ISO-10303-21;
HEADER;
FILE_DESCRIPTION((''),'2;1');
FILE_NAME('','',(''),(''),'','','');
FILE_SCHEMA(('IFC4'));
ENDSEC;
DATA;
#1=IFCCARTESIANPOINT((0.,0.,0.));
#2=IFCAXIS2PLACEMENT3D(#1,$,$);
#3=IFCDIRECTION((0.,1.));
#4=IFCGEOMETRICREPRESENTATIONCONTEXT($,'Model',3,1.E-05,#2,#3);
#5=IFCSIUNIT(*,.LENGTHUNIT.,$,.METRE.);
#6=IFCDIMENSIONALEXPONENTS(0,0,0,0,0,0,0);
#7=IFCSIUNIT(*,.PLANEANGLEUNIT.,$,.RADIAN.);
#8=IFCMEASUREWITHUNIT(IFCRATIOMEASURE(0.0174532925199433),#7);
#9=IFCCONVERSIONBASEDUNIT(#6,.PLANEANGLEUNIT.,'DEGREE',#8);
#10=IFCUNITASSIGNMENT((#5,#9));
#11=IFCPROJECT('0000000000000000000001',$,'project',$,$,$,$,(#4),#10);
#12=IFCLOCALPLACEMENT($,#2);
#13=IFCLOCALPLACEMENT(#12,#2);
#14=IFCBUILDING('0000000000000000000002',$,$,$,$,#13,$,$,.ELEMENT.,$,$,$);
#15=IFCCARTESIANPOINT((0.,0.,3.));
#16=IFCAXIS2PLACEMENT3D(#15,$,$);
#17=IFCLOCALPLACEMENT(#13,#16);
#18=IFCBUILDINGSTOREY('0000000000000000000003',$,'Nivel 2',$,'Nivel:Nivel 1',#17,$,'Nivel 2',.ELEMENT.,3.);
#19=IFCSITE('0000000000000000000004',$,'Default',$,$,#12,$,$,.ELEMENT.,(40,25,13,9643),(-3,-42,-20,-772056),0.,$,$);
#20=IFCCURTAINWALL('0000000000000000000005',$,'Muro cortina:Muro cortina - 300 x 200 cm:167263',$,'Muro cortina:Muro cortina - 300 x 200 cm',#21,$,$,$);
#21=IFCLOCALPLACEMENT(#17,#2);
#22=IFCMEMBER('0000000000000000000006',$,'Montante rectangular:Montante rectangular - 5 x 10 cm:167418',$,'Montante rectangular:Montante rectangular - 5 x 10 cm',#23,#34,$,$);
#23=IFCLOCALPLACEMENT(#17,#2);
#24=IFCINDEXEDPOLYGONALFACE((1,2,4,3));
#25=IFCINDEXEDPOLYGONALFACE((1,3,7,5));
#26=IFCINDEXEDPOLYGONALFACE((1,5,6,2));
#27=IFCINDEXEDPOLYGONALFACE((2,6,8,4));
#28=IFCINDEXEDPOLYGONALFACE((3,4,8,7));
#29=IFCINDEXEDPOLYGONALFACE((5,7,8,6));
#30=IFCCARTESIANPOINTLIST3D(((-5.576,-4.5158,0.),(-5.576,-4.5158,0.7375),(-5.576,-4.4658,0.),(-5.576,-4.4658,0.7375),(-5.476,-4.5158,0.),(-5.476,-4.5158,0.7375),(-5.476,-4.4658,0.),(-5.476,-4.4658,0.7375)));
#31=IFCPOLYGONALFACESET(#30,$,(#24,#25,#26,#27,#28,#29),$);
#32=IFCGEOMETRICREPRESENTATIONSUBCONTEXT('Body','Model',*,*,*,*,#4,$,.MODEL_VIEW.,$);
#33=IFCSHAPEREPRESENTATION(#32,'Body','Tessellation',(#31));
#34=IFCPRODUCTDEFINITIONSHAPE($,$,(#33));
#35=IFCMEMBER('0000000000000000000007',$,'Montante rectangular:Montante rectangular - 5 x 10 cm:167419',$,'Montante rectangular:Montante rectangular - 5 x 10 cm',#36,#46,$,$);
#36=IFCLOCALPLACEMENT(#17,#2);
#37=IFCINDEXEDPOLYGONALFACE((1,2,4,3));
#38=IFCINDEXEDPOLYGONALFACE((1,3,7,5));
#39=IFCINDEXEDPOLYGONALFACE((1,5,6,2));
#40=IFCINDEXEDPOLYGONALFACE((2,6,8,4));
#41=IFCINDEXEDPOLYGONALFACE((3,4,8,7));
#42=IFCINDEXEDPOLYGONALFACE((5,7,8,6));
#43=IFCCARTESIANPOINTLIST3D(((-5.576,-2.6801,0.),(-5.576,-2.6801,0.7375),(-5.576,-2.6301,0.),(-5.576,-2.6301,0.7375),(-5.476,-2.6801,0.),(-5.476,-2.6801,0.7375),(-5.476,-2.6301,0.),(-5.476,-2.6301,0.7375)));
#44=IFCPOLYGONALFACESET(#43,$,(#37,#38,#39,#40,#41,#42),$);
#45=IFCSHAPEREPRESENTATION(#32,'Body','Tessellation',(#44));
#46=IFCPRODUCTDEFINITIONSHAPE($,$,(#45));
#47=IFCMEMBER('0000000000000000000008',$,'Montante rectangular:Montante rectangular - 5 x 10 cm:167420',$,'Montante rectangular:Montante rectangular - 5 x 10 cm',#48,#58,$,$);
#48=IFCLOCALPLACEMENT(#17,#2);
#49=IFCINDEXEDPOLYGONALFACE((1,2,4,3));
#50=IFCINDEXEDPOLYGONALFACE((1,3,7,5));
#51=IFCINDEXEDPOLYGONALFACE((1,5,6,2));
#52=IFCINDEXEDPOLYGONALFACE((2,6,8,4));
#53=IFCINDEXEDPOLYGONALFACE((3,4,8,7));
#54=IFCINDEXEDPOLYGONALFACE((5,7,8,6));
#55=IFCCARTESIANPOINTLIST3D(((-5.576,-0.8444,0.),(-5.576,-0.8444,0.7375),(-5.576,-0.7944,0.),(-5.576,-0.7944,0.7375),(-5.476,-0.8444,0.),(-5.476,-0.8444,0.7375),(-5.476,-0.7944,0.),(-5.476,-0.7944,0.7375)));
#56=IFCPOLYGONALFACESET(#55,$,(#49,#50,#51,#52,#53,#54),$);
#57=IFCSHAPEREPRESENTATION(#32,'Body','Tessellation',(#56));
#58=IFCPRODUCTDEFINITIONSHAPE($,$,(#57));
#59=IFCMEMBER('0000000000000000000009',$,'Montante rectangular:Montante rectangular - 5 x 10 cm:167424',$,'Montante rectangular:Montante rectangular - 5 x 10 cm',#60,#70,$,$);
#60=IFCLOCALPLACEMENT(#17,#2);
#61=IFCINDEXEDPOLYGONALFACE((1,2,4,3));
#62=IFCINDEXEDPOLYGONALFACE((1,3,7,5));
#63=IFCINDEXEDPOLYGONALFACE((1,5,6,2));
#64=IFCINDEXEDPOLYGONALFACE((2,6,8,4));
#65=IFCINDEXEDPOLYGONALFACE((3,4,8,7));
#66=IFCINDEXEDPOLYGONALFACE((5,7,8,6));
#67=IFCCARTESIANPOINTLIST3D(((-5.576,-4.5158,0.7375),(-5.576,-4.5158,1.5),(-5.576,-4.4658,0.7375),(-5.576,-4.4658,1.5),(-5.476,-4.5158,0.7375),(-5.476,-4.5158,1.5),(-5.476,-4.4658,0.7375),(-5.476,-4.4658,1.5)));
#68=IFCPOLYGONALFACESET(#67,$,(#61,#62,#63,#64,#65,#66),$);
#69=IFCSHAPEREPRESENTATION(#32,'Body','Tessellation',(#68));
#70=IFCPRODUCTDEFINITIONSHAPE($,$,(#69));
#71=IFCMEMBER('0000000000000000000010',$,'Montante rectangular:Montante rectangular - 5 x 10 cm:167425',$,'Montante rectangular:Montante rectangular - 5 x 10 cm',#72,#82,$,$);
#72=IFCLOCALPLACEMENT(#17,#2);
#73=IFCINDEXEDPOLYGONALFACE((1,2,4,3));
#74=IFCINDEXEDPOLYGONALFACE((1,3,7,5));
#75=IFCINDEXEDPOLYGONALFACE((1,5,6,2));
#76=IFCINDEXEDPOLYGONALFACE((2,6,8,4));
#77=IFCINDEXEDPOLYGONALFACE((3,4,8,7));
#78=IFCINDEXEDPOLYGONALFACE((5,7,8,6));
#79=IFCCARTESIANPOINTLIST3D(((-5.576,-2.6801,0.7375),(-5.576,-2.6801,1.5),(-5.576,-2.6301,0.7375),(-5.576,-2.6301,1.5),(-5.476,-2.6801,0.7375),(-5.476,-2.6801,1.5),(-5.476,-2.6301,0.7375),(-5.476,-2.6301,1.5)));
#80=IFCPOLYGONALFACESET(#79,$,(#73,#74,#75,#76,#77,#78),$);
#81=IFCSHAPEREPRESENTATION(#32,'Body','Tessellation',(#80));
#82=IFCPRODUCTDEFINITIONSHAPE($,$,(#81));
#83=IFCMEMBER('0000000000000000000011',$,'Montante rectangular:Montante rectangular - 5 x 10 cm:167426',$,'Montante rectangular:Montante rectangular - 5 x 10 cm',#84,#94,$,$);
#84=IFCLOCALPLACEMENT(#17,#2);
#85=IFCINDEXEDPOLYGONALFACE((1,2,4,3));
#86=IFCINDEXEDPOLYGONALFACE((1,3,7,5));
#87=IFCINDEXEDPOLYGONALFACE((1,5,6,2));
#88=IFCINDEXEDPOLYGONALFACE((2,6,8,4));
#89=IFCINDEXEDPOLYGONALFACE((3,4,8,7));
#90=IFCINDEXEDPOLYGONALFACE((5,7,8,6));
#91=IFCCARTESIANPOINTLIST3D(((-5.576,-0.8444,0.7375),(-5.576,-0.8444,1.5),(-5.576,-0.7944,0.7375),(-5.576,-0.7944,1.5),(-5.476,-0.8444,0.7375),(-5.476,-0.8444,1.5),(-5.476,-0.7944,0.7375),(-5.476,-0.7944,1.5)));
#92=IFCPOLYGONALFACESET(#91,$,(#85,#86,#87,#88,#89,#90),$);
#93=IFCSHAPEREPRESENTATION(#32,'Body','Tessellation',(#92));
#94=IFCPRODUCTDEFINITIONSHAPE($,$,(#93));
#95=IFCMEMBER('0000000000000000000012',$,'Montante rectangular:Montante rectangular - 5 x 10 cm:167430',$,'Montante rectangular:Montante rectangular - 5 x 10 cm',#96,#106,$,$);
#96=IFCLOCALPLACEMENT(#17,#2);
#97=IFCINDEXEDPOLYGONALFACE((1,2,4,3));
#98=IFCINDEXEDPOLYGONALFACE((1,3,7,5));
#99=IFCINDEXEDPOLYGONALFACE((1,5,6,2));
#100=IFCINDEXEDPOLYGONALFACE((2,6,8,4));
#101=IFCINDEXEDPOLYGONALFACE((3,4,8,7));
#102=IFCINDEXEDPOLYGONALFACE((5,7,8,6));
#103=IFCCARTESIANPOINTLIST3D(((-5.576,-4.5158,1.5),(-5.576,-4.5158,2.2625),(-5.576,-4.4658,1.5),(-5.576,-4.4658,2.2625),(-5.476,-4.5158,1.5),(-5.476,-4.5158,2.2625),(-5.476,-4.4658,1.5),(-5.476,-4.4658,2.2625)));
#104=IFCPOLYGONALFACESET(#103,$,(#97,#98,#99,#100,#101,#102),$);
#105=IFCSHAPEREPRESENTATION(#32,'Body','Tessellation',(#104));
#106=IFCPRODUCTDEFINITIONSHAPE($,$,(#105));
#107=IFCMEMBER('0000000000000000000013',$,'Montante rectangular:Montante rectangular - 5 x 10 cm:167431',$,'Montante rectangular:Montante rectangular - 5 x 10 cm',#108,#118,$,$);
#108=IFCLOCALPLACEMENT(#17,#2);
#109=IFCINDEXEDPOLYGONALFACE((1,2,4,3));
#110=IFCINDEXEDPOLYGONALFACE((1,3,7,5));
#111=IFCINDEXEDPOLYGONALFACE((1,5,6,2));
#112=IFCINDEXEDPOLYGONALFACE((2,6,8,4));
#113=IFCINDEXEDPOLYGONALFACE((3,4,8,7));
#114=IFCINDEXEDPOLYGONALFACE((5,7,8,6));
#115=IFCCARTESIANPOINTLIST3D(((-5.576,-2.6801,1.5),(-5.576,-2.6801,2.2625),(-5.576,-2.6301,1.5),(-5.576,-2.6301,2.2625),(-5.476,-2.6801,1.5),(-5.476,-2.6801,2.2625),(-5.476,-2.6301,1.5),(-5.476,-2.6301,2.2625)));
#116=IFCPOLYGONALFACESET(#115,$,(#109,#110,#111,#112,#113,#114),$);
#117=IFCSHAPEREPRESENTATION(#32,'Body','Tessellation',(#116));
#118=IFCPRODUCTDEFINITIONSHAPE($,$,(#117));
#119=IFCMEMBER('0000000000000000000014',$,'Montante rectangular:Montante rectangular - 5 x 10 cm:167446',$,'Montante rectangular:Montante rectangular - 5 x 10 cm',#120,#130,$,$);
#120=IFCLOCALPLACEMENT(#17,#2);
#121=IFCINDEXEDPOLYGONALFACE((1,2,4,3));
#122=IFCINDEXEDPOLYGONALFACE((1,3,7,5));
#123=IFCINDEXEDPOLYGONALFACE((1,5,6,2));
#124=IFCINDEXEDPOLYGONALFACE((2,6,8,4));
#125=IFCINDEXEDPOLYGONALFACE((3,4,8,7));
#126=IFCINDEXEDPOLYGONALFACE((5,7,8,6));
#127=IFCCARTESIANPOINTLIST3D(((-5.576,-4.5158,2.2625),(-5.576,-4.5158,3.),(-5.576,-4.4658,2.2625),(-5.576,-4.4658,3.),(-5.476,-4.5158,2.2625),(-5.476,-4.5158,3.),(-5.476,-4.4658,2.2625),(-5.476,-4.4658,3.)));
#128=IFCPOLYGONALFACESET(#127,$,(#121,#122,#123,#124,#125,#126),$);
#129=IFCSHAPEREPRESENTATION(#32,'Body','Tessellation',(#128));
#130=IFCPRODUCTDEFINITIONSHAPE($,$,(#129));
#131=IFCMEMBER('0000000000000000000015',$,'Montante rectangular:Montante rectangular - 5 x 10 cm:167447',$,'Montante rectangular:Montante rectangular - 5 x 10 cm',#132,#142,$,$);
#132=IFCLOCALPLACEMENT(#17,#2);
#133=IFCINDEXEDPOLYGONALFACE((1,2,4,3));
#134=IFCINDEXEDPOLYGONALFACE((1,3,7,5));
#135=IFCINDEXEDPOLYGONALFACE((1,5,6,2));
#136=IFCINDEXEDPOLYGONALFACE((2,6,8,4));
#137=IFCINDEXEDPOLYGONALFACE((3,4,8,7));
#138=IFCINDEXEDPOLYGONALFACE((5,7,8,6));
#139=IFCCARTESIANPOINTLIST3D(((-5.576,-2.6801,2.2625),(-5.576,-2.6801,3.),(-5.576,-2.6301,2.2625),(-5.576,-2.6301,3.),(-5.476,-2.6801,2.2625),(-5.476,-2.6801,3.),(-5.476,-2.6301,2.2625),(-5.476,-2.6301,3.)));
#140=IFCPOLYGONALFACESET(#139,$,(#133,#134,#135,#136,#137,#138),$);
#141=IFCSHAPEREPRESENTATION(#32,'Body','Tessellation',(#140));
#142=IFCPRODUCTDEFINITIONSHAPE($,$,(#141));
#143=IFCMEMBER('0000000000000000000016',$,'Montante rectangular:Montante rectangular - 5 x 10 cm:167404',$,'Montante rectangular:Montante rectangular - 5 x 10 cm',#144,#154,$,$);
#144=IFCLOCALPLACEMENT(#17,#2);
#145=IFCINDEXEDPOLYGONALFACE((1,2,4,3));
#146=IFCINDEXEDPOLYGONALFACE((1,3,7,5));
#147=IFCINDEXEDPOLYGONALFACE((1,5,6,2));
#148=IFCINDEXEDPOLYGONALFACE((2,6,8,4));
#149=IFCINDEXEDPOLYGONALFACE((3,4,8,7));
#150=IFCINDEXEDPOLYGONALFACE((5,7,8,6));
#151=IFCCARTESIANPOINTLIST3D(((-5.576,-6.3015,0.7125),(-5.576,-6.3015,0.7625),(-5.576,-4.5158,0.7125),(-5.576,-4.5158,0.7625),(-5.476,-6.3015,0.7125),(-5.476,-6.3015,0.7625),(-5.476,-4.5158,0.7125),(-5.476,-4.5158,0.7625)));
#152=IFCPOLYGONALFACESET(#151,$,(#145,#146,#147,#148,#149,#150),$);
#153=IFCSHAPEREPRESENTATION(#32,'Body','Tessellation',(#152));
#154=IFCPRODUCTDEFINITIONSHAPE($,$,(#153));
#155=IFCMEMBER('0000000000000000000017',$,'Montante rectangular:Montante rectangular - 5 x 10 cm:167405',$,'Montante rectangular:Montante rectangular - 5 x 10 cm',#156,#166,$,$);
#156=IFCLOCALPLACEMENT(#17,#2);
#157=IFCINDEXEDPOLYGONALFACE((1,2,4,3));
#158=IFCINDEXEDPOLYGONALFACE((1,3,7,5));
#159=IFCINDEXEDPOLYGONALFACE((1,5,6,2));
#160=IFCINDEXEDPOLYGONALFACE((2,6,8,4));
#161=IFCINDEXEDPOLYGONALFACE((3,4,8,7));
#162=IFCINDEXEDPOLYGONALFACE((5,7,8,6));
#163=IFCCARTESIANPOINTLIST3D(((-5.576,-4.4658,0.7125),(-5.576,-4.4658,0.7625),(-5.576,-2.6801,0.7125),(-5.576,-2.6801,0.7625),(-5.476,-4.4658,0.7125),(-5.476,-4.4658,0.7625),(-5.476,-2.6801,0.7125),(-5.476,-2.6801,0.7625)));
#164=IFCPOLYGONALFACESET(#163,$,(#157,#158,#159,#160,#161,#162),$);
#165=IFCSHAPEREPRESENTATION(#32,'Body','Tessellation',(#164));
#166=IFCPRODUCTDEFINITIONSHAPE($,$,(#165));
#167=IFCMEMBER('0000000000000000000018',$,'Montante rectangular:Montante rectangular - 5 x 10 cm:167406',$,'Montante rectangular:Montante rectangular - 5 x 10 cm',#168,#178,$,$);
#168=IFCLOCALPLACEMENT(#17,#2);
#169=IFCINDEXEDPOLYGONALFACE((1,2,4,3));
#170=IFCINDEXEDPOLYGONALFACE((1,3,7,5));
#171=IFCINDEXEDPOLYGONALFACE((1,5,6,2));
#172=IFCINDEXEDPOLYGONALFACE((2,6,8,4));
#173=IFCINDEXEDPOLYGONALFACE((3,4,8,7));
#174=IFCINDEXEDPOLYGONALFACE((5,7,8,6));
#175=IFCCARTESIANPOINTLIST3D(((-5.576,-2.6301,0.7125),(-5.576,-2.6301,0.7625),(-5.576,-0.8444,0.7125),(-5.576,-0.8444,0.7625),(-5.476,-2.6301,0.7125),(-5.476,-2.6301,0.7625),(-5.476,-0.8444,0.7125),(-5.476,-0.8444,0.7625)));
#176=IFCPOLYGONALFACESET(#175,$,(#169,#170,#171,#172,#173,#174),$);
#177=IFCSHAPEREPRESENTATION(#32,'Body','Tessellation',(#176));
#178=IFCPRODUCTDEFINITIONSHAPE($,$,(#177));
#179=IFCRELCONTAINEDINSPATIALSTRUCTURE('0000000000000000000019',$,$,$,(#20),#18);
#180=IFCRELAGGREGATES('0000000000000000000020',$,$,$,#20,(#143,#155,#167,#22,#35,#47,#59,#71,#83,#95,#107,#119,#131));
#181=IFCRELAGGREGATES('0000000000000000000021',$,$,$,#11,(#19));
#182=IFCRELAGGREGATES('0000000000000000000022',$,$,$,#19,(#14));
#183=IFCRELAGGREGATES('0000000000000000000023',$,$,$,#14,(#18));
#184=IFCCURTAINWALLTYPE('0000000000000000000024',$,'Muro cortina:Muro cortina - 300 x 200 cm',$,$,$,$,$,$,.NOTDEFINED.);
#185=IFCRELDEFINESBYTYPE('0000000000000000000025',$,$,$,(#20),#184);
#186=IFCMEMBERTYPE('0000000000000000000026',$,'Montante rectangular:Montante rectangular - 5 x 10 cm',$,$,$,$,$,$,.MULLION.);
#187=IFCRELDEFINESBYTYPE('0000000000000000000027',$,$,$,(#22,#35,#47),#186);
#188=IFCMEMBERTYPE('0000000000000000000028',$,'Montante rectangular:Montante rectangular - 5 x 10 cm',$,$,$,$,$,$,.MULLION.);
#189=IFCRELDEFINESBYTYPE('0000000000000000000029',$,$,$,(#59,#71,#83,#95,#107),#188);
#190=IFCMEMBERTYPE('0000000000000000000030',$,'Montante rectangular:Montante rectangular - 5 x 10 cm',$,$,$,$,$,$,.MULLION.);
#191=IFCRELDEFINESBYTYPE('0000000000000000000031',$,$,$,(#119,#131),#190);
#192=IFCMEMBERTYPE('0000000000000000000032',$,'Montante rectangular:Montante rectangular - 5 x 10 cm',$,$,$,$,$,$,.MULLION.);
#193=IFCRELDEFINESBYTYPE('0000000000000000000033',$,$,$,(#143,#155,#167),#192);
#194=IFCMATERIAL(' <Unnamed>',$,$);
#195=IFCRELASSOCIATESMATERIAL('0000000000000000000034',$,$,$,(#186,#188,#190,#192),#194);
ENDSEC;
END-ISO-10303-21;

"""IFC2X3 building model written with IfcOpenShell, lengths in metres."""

from ifc_helpers import new_model, entity, si_unit, converted_unit, direction, frame, origin, origin_2d_with_axis, place, context, subcontext, project, spatial, rectangle, extrude, source, transform, mapped, material, type_object, type_shapes, element, aggregate, save


model = new_model("IFC2X3")

# Units and contexts
model_context = context("Model", 3, precision=1e-05, world=origin(), true_north=direction((0.0, 1.0)))
body_context = subcontext(model_context, "Body", "Model", "MODEL_VIEW")
ifc_project = project(units=[si_unit("LENGTHUNIT", "METRE"), converted_unit("PLANEANGLEUNIT", "DEGREE", entity("IfcRatioMeasure", 0.0174532925199433), si_unit("PLANEANGLEUNIT", "RADIAN"), dimensions=[0, 0, 0, 0, 0, 0, 0])], contexts=[model_context])

# Site, building, storey
site_placement = place(None, origin())
site = spatial("IfcSite", under=ifc_project, at=site_placement, Name="Default", CompositionType="ELEMENT", RefLatitude=(40, 25, 13, 9643), RefLongitude=(-3, -42, -20, -772056), RefElevation=0.0)
building_placement = place(site_placement, origin())
building = spatial("IfcBuilding", under=site, at=building_placement, CompositionType="ELEMENT")
storey_placement = place(building_placement, frame((0.0, 0.0, 3.0)))
storey = spatial("IfcBuildingStorey", under=building, at=storey_placement, Name="Nivel 2", ObjectType="Nivel:Nivel 1", LongName="Nivel 2", CompositionType="ELEMENT", Elevation=3.0)

# Curtain wall, members
curtain_wall_type = type_object("IfcCurtainWallType", Name="Muro cortina:Muro cortina - 300 x 200 cm", PredefinedType="NOTDEFINED")
curtain_wall_placement = place(storey_placement, frame((0.0, 0.0, -3.0)))
curtain_wall = element("IfcCurtainWall", 1, at=curtain_wall_placement, inside=storey, type_object=curtain_wall_type, Name="Muro cortina:Muro cortina - 300 x 200 cm:167263", ObjectType="Muro cortina:Muro cortina - 300 x 200 cm")
ifc_material_1 = material(Name=" <Unnamed>")
member_type_1 = type_object("IfcMemberType", Name="Montante rectangular:Montante rectangular - 5 x 10 cm", PredefinedType="MULLION", material=ifc_material_1)
shared_shape_1 = source(origin(), body_context, "Body", "SweptSolid", [
    extrude(rectangle(XDim=0.1, YDim=0.05, at=origin_2d_with_axis()), frame((0.0, 0.0, -0.7375), z_axis=(0.0, 0.0, 1.0), x_axis=(0.0, -1.0, 0.0)), (0.0, 0.0, 1.0), 0.7375),
])
type_shapes(member_type_1, [shared_shape_1])
member_1_placement = place(storey_placement, frame((-5.526, -4.4908, 0.0), z_axis=(0.0, 0.0, -1.0), x_axis=(0.0, 1.0, 0.0)))
member_1 = element("IfcMember", 2, at=member_1_placement, type_object=member_type_1, Name="Montante rectangular:Montante rectangular - 5 x 10 cm:167418", ObjectType="Montante rectangular:Montante rectangular - 5 x 10 cm", context=body_context, shape_type="MappedRepresentation", body=[
    mapped(shared_shape_1, transform((0.0, 0.0, 0.0), scale=1.0)),
])
member_2_placement = place(storey_placement, frame((-5.526, -2.6551, 0.0), z_axis=(0.0, 0.0, -1.0), x_axis=(0.0, 1.0, 0.0)))
member_2 = element("IfcMember", 3, at=member_2_placement, type_object=member_type_1, Name="Montante rectangular:Montante rectangular - 5 x 10 cm:167419", ObjectType="Montante rectangular:Montante rectangular - 5 x 10 cm", context=body_context, shape_type="MappedRepresentation", body=[
    mapped(shared_shape_1, transform((0.0, 0.0, 0.0), scale=1.0)),
])
member_3_placement = place(storey_placement, frame((-5.526, -0.8194, 0.0), z_axis=(0.0, 0.0, -1.0), x_axis=(0.0, 1.0, 0.0)))
member_3 = element("IfcMember", 4, at=member_3_placement, type_object=member_type_1, Name="Montante rectangular:Montante rectangular - 5 x 10 cm:167420", ObjectType="Montante rectangular:Montante rectangular - 5 x 10 cm", context=body_context, shape_type="MappedRepresentation", body=[
    mapped(shared_shape_1, transform((0.0, 0.0, 0.0), scale=1.0)),
])
member_type_2 = type_object("IfcMemberType", Name="Montante rectangular:Montante rectangular - 5 x 10 cm", PredefinedType="MULLION", material=ifc_material_1)
shared_shape_2 = source(origin(), body_context, "Body", "SweptSolid", [
    extrude(rectangle(XDim=0.1, YDim=0.05, at=origin_2d_with_axis()), frame((0.0, 0.0, -0.7625), z_axis=(0.0, 0.0, 1.0), x_axis=(0.0, -1.0, 0.0)), (0.0, 0.0, 1.0), 0.7625),
])
type_shapes(member_type_2, [shared_shape_2])
member_4_placement = place(storey_placement, frame((-5.526, -4.4908, 0.7375), z_axis=(0.0, 0.0, -1.0), x_axis=(0.0, 1.0, 0.0)))
member_4 = element("IfcMember", 5, at=member_4_placement, type_object=member_type_2, Name="Montante rectangular:Montante rectangular - 5 x 10 cm:167424", ObjectType="Montante rectangular:Montante rectangular - 5 x 10 cm", context=body_context, shape_type="MappedRepresentation", body=[
    mapped(shared_shape_2, transform((0.0, 0.0, 0.0), scale=1.0)),
])
member_5_placement = place(storey_placement, frame((-5.526, -2.6551, 0.7375), z_axis=(0.0, 0.0, -1.0), x_axis=(0.0, 1.0, 0.0)))
member_5 = element("IfcMember", 6, at=member_5_placement, type_object=member_type_2, Name="Montante rectangular:Montante rectangular - 5 x 10 cm:167425", ObjectType="Montante rectangular:Montante rectangular - 5 x 10 cm", context=body_context, shape_type="MappedRepresentation", body=[
    mapped(shared_shape_2, transform((0.0, 0.0, 0.0), scale=1.0)),
])
member_6_placement = place(storey_placement, frame((-5.526, -0.8194, 0.7375), z_axis=(0.0, 0.0, -1.0), x_axis=(0.0, 1.0, 0.0)))
member_6 = element("IfcMember", 7, at=member_6_placement, type_object=member_type_2, Name="Montante rectangular:Montante rectangular - 5 x 10 cm:167426", ObjectType="Montante rectangular:Montante rectangular - 5 x 10 cm", context=body_context, shape_type="MappedRepresentation", body=[
    mapped(shared_shape_2, transform((0.0, 0.0, 0.0), scale=1.0)),
])
member_7_placement = place(storey_placement, frame((-5.526, -4.4908, 1.5), z_axis=(0.0, 0.0, -1.0), x_axis=(0.0, 1.0, 0.0)))
member_7 = element("IfcMember", 8, at=member_7_placement, type_object=member_type_2, Name="Montante rectangular:Montante rectangular - 5 x 10 cm:167430", ObjectType="Montante rectangular:Montante rectangular - 5 x 10 cm", context=body_context, shape_type="MappedRepresentation", body=[
    mapped(shared_shape_2, transform((0.0, 0.0, 0.0), scale=1.0)),
])
member_8_placement = place(storey_placement, frame((-5.526, -2.6551, 1.5), z_axis=(0.0, 0.0, -1.0), x_axis=(0.0, 1.0, 0.0)))
member_8 = element("IfcMember", 9, at=member_8_placement, type_object=member_type_2, Name="Montante rectangular:Montante rectangular - 5 x 10 cm:167431", ObjectType="Montante rectangular:Montante rectangular - 5 x 10 cm", context=body_context, shape_type="MappedRepresentation", body=[
    mapped(shared_shape_2, transform((0.0, 0.0, 0.0), scale=1.0)),
])
member_type_3 = type_object("IfcMemberType", Name="Montante rectangular:Montante rectangular - 5 x 10 cm", PredefinedType="MULLION", material=ifc_material_1)
shared_shape_3 = source(origin(), body_context, "Body", "SweptSolid", [
    extrude(rectangle(XDim=0.1, YDim=0.05, at=origin_2d_with_axis()), frame((0.0, 0.0, -0.7375), z_axis=(0.0, 0.0, 1.0), x_axis=(0.0, -1.0, 0.0)), (0.0, 0.0, 1.0), 0.7375),
])
type_shapes(member_type_3, [shared_shape_3])
member_9_placement = place(storey_placement, frame((-5.526, -4.4908, 2.2625), z_axis=(0.0, 0.0, -1.0), x_axis=(0.0, 1.0, 0.0)))
member_9 = element("IfcMember", 10, at=member_9_placement, type_object=member_type_3, Name="Montante rectangular:Montante rectangular - 5 x 10 cm:167446", ObjectType="Montante rectangular:Montante rectangular - 5 x 10 cm", context=body_context, shape_type="MappedRepresentation", body=[
    mapped(shared_shape_3, transform((0.0, 0.0, 0.0), scale=1.0)),
])
member_10_placement = place(storey_placement, frame((-5.526, -2.6551, 2.2625), z_axis=(0.0, 0.0, -1.0), x_axis=(0.0, 1.0, 0.0)))
member_10 = element("IfcMember", 11, at=member_10_placement, type_object=member_type_3, Name="Montante rectangular:Montante rectangular - 5 x 10 cm:167447", ObjectType="Montante rectangular:Montante rectangular - 5 x 10 cm", context=body_context, shape_type="MappedRepresentation", body=[
    mapped(shared_shape_3, transform((0.0, 0.0, 0.0), scale=1.0)),
])
member_type_4 = type_object("IfcMemberType", Name="Montante rectangular:Montante rectangular - 5 x 10 cm", PredefinedType="MULLION", material=ifc_material_1)
shared_shape_4 = source(origin(), body_context, "Body", "SweptSolid", [
    extrude(rectangle(XDim=0.1, YDim=0.05, at=origin_2d_with_axis()), frame((0.0, 0.0, -1.7857), z_axis=(0.0, 0.0, 1.0), x_axis=(0.0, -1.0, 0.0)), (0.0, 0.0, 1.0), 1.7857),
])
type_shapes(member_type_4, [shared_shape_4])
member_11_placement = place(storey_placement, frame((-5.526, -4.5158, 0.7375), z_axis=(0.0, 1.0, 0.0), x_axis=(0.0, 0.0, 1.0)))
member_11 = element("IfcMember", 12, at=member_11_placement, type_object=member_type_4, Name="Montante rectangular:Montante rectangular - 5 x 10 cm:167404", ObjectType="Montante rectangular:Montante rectangular - 5 x 10 cm", context=body_context, shape_type="MappedRepresentation", body=[
    mapped(shared_shape_4, transform((0.0, 0.0, 0.0), scale=1.0)),
])
member_12_placement = place(storey_placement, frame((-5.526, -2.6801, 0.7375), z_axis=(0.0, 1.0, 0.0), x_axis=(0.0, 0.0, 1.0)))
member_12 = element("IfcMember", 13, at=member_12_placement, type_object=member_type_4, Name="Montante rectangular:Montante rectangular - 5 x 10 cm:167405", ObjectType="Montante rectangular:Montante rectangular - 5 x 10 cm", context=body_context, shape_type="MappedRepresentation", body=[
    mapped(shared_shape_4, transform((0.0, 0.0, 0.0), scale=1.0)),
])
member_13_placement = place(storey_placement, frame((-5.526, -0.8444, 0.7375), z_axis=(0.0, 1.0, 0.0), x_axis=(0.0, 0.0, 1.0)))
member_13 = element("IfcMember", 14, at=member_13_placement, type_object=member_type_4, Name="Montante rectangular:Montante rectangular - 5 x 10 cm:167406", ObjectType="Montante rectangular:Montante rectangular - 5 x 10 cm", context=body_context, shape_type="MappedRepresentation", body=[
    mapped(shared_shape_4, transform((0.0, 0.0, 0.0), scale=1.0)),
])
aggregate(curtain_wall, [member_11, member_12, member_13, member_1, member_2, member_3, member_4, member_5, member_6, member_7, member_8, member_9, member_10])

save(model, "model.ifc")
